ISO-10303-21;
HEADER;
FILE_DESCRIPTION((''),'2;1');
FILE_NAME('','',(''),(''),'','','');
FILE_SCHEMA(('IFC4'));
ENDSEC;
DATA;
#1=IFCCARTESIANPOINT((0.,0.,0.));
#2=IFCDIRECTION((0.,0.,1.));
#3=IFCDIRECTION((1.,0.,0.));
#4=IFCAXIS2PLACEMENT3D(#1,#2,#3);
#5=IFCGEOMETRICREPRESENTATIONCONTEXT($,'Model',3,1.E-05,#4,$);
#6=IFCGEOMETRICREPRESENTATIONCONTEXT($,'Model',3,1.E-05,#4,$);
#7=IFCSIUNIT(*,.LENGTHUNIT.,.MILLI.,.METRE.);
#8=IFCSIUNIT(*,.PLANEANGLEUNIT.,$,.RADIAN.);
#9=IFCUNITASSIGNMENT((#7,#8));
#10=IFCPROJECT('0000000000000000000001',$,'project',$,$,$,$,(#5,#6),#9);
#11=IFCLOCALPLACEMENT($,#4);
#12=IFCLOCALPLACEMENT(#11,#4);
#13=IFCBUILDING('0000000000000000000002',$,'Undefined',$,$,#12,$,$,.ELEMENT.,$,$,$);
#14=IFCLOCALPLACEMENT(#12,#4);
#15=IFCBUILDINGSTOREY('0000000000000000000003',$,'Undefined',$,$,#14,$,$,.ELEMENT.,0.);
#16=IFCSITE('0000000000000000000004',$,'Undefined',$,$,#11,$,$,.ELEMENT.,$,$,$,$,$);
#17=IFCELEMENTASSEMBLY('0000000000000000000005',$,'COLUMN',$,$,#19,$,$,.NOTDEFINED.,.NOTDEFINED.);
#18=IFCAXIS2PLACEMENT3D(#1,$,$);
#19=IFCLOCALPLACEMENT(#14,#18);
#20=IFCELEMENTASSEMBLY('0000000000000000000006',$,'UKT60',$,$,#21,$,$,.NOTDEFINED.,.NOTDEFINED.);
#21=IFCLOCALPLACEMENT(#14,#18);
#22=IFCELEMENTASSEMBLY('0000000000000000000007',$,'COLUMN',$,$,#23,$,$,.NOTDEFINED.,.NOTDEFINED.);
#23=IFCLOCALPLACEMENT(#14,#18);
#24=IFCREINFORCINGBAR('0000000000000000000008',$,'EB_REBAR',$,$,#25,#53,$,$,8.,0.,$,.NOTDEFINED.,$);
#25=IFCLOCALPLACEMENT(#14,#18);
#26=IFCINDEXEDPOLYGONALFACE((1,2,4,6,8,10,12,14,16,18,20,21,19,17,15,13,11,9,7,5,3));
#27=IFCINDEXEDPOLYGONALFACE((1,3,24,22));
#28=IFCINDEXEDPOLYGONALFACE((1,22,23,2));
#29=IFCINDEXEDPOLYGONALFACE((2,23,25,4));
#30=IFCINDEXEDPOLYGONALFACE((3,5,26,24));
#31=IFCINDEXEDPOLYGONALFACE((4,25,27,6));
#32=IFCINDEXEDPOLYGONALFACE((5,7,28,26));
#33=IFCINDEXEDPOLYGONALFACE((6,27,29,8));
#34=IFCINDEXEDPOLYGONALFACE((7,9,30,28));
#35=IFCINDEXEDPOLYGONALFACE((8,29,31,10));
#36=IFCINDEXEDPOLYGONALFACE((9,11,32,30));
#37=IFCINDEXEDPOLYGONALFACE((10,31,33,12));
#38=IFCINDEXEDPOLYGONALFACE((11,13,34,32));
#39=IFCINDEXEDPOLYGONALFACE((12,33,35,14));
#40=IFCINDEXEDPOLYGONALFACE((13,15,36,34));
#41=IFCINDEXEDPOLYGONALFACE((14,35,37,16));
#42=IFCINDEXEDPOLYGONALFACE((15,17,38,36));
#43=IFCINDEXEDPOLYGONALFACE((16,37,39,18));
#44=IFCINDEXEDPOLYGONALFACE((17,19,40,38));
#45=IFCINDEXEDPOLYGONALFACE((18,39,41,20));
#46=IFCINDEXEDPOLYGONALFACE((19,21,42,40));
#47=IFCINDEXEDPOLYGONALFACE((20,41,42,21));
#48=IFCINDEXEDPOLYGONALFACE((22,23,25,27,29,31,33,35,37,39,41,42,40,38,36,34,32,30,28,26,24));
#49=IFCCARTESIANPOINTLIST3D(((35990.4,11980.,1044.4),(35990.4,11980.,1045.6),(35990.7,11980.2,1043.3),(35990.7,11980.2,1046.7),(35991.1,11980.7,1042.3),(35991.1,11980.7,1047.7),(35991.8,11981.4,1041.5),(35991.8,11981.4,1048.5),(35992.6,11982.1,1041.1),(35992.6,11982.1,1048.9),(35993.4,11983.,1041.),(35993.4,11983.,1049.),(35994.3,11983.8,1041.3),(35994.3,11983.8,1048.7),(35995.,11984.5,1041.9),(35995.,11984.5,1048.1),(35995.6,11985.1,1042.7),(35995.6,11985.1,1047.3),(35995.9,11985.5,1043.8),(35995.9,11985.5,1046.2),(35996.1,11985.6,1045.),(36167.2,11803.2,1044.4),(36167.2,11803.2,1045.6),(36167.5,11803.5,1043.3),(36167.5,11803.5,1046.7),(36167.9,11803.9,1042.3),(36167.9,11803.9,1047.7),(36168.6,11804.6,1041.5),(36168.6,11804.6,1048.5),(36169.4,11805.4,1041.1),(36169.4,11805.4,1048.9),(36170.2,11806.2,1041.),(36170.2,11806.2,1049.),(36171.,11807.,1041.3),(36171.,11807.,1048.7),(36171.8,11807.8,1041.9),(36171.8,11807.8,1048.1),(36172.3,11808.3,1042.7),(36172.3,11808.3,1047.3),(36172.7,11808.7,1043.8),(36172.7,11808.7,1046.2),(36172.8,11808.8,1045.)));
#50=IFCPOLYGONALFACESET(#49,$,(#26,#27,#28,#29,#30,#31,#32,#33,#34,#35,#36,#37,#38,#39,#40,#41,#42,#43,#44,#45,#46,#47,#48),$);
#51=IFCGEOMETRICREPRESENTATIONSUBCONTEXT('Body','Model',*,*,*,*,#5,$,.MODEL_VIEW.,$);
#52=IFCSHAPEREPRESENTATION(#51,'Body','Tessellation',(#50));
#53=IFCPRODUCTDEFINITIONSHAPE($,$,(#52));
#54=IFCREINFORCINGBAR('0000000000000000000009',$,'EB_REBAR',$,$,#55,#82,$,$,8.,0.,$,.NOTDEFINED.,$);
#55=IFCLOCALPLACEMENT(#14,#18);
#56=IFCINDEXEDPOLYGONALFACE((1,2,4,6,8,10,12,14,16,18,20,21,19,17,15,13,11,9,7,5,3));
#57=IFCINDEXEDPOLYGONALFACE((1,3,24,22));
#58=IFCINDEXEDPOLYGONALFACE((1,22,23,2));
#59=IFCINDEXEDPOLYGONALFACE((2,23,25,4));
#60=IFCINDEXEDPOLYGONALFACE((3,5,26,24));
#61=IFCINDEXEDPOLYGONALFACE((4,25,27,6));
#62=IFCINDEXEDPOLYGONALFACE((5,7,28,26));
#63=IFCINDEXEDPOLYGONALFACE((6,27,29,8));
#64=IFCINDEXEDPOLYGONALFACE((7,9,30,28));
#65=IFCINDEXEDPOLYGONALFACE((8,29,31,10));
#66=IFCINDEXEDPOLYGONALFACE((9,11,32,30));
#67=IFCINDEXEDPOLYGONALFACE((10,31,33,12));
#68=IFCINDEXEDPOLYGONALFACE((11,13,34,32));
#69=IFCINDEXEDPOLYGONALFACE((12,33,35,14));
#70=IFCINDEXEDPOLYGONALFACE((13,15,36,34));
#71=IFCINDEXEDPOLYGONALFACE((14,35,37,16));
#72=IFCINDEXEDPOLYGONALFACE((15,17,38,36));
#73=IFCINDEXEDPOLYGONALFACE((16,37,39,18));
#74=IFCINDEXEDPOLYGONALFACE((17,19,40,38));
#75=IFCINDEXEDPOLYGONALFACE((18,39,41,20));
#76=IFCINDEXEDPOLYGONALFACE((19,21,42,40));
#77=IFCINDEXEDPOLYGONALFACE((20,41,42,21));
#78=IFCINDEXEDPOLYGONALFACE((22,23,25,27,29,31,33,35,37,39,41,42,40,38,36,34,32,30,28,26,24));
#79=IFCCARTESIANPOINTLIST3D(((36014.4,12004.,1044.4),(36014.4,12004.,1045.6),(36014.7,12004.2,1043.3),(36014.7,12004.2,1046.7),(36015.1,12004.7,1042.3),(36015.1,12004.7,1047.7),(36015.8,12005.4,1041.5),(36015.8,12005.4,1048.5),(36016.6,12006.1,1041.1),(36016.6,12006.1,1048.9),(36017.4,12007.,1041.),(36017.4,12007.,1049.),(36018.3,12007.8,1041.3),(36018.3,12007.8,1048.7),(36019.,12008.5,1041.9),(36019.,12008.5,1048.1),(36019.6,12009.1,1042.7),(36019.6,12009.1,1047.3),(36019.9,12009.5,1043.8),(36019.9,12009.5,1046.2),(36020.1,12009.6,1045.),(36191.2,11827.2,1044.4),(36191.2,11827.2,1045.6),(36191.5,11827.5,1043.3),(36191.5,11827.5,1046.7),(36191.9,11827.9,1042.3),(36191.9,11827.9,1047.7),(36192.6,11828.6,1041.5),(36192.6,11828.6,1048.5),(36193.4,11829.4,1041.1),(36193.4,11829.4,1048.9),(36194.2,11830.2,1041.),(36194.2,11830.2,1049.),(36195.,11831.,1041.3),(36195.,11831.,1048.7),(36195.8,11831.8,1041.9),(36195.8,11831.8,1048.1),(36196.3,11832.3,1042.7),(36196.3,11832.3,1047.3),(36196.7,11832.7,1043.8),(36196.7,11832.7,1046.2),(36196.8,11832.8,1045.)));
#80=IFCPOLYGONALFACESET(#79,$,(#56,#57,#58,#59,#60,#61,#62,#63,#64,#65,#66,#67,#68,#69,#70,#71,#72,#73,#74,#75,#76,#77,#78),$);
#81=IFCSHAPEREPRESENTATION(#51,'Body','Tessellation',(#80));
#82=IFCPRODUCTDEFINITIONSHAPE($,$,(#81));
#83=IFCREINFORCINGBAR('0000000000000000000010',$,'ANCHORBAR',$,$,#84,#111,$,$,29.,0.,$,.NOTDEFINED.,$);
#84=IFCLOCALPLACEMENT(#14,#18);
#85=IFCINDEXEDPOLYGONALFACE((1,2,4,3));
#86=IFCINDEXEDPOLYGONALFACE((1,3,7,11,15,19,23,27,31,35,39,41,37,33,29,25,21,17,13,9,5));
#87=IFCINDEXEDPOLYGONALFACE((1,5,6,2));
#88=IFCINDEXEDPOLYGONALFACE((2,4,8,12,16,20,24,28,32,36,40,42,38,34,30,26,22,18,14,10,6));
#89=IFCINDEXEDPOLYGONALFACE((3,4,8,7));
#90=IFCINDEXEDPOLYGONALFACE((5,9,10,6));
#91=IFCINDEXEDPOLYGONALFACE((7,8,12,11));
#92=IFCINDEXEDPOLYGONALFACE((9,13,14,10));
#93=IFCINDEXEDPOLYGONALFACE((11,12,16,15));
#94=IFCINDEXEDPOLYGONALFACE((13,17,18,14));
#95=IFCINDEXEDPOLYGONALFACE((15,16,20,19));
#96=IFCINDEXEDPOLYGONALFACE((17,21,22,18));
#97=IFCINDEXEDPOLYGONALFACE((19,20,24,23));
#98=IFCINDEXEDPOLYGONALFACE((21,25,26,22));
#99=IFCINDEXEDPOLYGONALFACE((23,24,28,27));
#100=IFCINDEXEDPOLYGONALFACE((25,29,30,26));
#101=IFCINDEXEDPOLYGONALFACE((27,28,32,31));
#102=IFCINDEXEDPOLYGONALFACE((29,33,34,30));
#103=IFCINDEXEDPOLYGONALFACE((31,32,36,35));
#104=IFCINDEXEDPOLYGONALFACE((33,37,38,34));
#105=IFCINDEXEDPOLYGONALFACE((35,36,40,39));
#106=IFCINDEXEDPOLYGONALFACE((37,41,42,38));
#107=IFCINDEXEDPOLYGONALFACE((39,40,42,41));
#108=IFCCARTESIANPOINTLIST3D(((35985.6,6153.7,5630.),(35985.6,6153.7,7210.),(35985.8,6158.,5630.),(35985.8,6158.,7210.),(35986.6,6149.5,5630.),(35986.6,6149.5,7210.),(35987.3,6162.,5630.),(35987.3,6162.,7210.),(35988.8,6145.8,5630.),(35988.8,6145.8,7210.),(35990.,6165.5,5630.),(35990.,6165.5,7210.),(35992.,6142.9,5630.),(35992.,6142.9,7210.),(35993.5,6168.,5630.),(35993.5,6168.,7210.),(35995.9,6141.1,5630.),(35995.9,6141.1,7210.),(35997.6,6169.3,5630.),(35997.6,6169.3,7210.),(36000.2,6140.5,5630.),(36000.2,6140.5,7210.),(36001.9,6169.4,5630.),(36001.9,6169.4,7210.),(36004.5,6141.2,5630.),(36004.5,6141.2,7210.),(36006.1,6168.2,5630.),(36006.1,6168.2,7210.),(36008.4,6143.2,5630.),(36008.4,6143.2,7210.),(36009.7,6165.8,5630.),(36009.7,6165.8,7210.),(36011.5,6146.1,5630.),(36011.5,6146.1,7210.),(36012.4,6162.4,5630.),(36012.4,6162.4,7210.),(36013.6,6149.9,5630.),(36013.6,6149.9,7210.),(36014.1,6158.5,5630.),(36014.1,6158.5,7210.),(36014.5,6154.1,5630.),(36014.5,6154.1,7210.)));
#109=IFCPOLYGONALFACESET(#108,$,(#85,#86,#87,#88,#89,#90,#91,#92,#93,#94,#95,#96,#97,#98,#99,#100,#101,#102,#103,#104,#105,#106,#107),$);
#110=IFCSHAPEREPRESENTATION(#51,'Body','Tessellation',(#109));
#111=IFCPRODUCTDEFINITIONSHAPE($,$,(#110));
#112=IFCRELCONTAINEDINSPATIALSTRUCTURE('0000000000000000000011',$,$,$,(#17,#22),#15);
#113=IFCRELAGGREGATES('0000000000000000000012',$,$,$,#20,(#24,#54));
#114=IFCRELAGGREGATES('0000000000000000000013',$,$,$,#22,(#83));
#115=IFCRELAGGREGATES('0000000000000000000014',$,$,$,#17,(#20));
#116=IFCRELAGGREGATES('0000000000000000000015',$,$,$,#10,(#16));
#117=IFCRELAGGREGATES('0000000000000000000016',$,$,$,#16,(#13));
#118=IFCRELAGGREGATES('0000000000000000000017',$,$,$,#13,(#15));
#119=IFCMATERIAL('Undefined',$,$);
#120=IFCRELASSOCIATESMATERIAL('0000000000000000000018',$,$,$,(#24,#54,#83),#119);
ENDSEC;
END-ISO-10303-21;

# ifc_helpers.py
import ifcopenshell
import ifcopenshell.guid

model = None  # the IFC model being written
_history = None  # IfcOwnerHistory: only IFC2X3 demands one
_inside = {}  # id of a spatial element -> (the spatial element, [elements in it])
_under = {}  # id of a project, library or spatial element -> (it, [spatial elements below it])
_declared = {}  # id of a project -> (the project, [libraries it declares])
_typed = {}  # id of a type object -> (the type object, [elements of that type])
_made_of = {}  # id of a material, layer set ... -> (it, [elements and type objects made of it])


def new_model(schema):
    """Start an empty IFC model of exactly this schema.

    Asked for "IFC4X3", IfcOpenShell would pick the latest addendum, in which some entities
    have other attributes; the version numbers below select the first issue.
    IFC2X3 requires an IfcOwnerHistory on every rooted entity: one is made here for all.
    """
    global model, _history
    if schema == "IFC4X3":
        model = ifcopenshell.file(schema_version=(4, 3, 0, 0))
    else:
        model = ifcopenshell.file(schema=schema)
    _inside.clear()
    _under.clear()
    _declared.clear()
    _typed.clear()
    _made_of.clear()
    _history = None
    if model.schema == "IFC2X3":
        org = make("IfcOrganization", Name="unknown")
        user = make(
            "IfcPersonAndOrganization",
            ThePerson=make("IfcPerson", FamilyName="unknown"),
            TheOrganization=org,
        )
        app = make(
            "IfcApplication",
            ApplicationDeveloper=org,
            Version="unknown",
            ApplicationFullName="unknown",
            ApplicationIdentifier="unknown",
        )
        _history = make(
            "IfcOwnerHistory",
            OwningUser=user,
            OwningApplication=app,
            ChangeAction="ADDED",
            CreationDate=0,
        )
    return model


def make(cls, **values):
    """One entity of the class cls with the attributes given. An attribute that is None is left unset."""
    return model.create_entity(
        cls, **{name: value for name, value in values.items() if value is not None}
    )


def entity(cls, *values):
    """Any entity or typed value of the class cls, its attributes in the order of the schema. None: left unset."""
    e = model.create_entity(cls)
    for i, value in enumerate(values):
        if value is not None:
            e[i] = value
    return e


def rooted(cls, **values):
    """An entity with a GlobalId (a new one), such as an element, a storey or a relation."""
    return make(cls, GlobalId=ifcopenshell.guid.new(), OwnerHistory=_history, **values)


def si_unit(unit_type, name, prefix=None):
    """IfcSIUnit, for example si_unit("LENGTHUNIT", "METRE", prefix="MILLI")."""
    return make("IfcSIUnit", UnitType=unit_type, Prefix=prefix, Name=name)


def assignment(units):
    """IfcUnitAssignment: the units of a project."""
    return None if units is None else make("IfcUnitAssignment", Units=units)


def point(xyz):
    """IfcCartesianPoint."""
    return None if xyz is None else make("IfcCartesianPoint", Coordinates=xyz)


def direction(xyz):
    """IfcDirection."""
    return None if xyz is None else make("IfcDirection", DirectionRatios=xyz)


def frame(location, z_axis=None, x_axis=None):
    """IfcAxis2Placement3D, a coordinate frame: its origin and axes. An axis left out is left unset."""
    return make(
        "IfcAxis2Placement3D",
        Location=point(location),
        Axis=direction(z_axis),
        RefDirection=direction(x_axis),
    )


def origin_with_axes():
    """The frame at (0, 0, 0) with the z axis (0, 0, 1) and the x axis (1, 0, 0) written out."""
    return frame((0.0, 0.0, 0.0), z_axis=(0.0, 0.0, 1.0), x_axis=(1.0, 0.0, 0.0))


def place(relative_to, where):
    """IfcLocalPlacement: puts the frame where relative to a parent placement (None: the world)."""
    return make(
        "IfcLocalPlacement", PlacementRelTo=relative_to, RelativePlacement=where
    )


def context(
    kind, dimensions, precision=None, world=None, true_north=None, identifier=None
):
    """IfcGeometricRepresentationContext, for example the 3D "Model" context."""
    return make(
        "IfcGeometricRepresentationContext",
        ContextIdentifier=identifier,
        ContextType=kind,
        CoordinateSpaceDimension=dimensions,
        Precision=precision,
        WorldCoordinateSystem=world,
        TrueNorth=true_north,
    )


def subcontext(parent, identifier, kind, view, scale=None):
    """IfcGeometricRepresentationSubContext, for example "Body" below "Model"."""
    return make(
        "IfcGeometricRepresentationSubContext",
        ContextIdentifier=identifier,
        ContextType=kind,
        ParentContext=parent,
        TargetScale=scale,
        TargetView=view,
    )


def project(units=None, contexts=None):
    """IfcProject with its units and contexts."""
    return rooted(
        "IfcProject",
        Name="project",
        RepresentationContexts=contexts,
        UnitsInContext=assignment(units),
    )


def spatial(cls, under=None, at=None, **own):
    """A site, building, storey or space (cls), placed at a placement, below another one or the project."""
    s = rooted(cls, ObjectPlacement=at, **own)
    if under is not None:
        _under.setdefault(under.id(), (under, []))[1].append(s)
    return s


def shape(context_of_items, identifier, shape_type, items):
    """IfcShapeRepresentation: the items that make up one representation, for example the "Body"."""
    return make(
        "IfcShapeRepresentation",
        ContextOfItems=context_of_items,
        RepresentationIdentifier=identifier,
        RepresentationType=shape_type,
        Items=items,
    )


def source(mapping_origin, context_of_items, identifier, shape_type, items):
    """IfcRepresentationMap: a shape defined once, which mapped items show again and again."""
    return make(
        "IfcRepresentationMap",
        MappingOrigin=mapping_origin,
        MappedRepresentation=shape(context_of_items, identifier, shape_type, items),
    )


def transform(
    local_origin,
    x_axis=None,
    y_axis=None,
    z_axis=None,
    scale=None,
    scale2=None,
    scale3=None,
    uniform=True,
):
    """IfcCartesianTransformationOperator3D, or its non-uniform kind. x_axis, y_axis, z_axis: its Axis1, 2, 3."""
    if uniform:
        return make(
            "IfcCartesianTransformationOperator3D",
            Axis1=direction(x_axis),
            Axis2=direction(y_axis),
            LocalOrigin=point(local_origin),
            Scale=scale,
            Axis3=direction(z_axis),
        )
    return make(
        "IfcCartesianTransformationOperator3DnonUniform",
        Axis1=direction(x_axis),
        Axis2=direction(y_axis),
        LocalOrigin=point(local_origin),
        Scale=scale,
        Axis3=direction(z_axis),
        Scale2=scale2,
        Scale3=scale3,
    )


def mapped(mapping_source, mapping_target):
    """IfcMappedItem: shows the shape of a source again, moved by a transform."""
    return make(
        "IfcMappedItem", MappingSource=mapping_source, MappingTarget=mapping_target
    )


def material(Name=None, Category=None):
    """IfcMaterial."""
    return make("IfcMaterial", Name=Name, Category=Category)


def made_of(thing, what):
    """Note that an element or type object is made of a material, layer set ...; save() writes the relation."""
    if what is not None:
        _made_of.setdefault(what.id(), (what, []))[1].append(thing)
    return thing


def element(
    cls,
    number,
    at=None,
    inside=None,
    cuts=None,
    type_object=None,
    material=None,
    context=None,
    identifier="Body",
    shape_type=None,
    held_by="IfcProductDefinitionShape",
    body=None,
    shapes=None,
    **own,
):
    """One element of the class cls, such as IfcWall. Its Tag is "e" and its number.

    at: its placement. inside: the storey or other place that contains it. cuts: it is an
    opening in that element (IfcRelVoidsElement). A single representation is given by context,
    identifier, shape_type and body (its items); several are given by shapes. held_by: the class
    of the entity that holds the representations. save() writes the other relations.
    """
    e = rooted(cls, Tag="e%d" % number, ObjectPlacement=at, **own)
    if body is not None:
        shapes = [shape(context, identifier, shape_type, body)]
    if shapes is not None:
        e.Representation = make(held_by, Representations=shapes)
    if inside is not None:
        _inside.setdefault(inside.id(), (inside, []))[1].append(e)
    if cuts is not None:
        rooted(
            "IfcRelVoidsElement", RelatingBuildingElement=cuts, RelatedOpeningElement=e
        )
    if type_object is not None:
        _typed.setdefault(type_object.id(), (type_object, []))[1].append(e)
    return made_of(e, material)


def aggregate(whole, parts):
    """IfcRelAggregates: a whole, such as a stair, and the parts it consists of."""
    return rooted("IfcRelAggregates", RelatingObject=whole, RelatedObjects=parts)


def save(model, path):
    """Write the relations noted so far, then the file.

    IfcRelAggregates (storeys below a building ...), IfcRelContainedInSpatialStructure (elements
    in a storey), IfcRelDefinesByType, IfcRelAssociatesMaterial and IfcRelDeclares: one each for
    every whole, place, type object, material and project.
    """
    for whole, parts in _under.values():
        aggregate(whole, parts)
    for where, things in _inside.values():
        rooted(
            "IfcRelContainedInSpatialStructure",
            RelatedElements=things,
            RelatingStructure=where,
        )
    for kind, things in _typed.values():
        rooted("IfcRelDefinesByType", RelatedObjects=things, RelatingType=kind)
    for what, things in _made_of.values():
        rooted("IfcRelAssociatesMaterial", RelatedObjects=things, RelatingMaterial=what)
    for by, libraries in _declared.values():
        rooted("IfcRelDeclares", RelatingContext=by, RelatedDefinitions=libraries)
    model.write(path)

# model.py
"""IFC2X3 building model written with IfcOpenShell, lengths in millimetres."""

from ifc_helpers import new_model, entity, si_unit, frame, origin_with_axes, place, context, subcontext, project, spatial, source, transform, mapped, material, element, aggregate, save


model = new_model("IFC2X3")

# Units and contexts
model_context_1 = context("Model", 3, precision=1e-05, world=origin_with_axes())
model_context_2 = context("Model", 3, precision=1e-05, world=origin_with_axes())
body_context = subcontext(model_context_1, "Body", "Model", "MODEL_VIEW")
ifc_project = project(units=[si_unit("LENGTHUNIT", "METRE", prefix="MILLI"), si_unit("PLANEANGLEUNIT", "RADIAN")], contexts=[model_context_1, model_context_2])

# Site, building, storey
site_placement = place(None, origin_with_axes())
site = spatial("IfcSite", under=ifc_project, at=site_placement, Name="Undefined", CompositionType="ELEMENT")
building_placement = place(site_placement, origin_with_axes())
building = spatial("IfcBuilding", under=site, at=building_placement, Name="Undefined", CompositionType="ELEMENT")
storey_placement = place(building_placement, origin_with_axes())
storey = spatial("IfcBuildingStorey", under=building, at=storey_placement, Name="Undefined", CompositionType="ELEMENT", Elevation=0.0)

# Element assemblies
assembly_1_placement = place(storey_placement, origin_with_axes())
assembly_1 = element("IfcElementAssembly", 1, at=assembly_1_placement, inside=storey, Name="COLUMN", AssemblyPlace="NOTDEFINED", PredefinedType="NOTDEFINED")
assembly_2_placement = place(assembly_1_placement, origin_with_axes())
assembly_2 = element("IfcElementAssembly", 2, at=assembly_2_placement, Name="UKT60", AssemblyPlace="NOTDEFINED", PredefinedType="NOTDEFINED")

# Element assembly
assembly_3_placement = place(storey_placement, origin_with_axes())
assembly_3 = element("IfcElementAssembly", 3, at=assembly_3_placement, inside=storey, Name="COLUMN", AssemblyPlace="NOTDEFINED", PredefinedType="NOTDEFINED")

# Reinforcing bars
ifc_material_1 = material(Name="Undefined")
shared_shape_1 = source(origin_with_axes(), body_context, "Body", "AdvancedSweptSolid", [
    entity("IfcSweptDiskSolid", entity("IfcTrimmedCurve", entity("IfcLine", entity("IfcCartesianPoint", [0.0, 0.0, 0.0]), entity("IfcVector", entity("IfcDirection", [1.0, 0.0, 0.0]), 1.0)), [entity("IfcParameterValue", 0.0)], [entity("IfcParameterValue", 250.0)], True, "PARAMETER"), 4.0, None, 0.0, 250.0),
])
reinforcing_bar_1_placement = place(assembly_2_placement, frame((36170.0, 11806.0, 1045.0), z_axis=(0.707107, 0.707107, 0.0), x_axis=(-0.707107, 0.707107, 0.0)))
reinforcing_bar_1 = element("IfcReinforcingBar", 4, at=reinforcing_bar_1_placement, material=ifc_material_1, Name="EB_REBAR", BarRole="NOTDEFINED", CrossSectionArea=0.0, NominalDiameter=8.0, context=body_context, shape_type="MappedRepresentation", body=[
    mapped(shared_shape_1, transform((0.0, 0.0, 0.0))),
])
shared_shape_2 = source(origin_with_axes(), body_context, "Body", "AdvancedSweptSolid", [
    entity("IfcSweptDiskSolid", entity("IfcTrimmedCurve", entity("IfcLine", entity("IfcCartesianPoint", [0.0, 0.0, 0.0]), entity("IfcVector", entity("IfcDirection", [1.0, 0.0, 0.0]), 1.0)), [entity("IfcParameterValue", 0.0)], [entity("IfcParameterValue", 250.0)], True, "PARAMETER"), 4.0, None, 0.0, 250.0),
])
reinforcing_bar_2_placement = place(assembly_2_placement, frame((36194.0, 11830.0, 1045.0), z_axis=(0.707107, 0.707107, 0.0), x_axis=(-0.707107, 0.707107, 0.0)))
reinforcing_bar_2 = element("IfcReinforcingBar", 5, at=reinforcing_bar_2_placement, material=ifc_material_1, Name="EB_REBAR", BarRole="NOTDEFINED", CrossSectionArea=0.0, NominalDiameter=8.0, context=body_context, shape_type="MappedRepresentation", body=[
    mapped(shared_shape_2, transform((0.0, 0.0, 0.0))),
])
aggregate(assembly_2, [reinforcing_bar_1, reinforcing_bar_2])
shared_shape_3 = source(origin_with_axes(), body_context, "Body", "AdvancedSweptSolid", [
    entity("IfcSweptDiskSolid", entity("IfcTrimmedCurve", entity("IfcLine", entity("IfcCartesianPoint", [0.0, 0.0, 0.0]), entity("IfcVector", entity("IfcDirection", [1.0, 0.0, 0.0]), 1.0)), [entity("IfcParameterValue", 0.0)], [entity("IfcParameterValue", 1580.0)], True, "PARAMETER"), 14.5, None, 0.0, 1580.0),
])
reinforcing_bar_3_placement = place(assembly_3_placement, frame((36000.0, 6155.0, 7210.0), z_axis=(-0.164799, 0.986327, 0.0), x_axis=(0.0, 0.0, -1.0)))
reinforcing_bar_3 = element("IfcReinforcingBar", 6, at=reinforcing_bar_3_placement, material=ifc_material_1, Name="ANCHORBAR", BarRole="NOTDEFINED", CrossSectionArea=0.0, NominalDiameter=29.0, context=body_context, shape_type="MappedRepresentation", body=[
    mapped(shared_shape_3, transform((0.0, 0.0, 0.0))),
])
aggregate(assembly_3, [reinforcing_bar_3])
aggregate(assembly_1, [assembly_2])

save(model, "model.ifc")
